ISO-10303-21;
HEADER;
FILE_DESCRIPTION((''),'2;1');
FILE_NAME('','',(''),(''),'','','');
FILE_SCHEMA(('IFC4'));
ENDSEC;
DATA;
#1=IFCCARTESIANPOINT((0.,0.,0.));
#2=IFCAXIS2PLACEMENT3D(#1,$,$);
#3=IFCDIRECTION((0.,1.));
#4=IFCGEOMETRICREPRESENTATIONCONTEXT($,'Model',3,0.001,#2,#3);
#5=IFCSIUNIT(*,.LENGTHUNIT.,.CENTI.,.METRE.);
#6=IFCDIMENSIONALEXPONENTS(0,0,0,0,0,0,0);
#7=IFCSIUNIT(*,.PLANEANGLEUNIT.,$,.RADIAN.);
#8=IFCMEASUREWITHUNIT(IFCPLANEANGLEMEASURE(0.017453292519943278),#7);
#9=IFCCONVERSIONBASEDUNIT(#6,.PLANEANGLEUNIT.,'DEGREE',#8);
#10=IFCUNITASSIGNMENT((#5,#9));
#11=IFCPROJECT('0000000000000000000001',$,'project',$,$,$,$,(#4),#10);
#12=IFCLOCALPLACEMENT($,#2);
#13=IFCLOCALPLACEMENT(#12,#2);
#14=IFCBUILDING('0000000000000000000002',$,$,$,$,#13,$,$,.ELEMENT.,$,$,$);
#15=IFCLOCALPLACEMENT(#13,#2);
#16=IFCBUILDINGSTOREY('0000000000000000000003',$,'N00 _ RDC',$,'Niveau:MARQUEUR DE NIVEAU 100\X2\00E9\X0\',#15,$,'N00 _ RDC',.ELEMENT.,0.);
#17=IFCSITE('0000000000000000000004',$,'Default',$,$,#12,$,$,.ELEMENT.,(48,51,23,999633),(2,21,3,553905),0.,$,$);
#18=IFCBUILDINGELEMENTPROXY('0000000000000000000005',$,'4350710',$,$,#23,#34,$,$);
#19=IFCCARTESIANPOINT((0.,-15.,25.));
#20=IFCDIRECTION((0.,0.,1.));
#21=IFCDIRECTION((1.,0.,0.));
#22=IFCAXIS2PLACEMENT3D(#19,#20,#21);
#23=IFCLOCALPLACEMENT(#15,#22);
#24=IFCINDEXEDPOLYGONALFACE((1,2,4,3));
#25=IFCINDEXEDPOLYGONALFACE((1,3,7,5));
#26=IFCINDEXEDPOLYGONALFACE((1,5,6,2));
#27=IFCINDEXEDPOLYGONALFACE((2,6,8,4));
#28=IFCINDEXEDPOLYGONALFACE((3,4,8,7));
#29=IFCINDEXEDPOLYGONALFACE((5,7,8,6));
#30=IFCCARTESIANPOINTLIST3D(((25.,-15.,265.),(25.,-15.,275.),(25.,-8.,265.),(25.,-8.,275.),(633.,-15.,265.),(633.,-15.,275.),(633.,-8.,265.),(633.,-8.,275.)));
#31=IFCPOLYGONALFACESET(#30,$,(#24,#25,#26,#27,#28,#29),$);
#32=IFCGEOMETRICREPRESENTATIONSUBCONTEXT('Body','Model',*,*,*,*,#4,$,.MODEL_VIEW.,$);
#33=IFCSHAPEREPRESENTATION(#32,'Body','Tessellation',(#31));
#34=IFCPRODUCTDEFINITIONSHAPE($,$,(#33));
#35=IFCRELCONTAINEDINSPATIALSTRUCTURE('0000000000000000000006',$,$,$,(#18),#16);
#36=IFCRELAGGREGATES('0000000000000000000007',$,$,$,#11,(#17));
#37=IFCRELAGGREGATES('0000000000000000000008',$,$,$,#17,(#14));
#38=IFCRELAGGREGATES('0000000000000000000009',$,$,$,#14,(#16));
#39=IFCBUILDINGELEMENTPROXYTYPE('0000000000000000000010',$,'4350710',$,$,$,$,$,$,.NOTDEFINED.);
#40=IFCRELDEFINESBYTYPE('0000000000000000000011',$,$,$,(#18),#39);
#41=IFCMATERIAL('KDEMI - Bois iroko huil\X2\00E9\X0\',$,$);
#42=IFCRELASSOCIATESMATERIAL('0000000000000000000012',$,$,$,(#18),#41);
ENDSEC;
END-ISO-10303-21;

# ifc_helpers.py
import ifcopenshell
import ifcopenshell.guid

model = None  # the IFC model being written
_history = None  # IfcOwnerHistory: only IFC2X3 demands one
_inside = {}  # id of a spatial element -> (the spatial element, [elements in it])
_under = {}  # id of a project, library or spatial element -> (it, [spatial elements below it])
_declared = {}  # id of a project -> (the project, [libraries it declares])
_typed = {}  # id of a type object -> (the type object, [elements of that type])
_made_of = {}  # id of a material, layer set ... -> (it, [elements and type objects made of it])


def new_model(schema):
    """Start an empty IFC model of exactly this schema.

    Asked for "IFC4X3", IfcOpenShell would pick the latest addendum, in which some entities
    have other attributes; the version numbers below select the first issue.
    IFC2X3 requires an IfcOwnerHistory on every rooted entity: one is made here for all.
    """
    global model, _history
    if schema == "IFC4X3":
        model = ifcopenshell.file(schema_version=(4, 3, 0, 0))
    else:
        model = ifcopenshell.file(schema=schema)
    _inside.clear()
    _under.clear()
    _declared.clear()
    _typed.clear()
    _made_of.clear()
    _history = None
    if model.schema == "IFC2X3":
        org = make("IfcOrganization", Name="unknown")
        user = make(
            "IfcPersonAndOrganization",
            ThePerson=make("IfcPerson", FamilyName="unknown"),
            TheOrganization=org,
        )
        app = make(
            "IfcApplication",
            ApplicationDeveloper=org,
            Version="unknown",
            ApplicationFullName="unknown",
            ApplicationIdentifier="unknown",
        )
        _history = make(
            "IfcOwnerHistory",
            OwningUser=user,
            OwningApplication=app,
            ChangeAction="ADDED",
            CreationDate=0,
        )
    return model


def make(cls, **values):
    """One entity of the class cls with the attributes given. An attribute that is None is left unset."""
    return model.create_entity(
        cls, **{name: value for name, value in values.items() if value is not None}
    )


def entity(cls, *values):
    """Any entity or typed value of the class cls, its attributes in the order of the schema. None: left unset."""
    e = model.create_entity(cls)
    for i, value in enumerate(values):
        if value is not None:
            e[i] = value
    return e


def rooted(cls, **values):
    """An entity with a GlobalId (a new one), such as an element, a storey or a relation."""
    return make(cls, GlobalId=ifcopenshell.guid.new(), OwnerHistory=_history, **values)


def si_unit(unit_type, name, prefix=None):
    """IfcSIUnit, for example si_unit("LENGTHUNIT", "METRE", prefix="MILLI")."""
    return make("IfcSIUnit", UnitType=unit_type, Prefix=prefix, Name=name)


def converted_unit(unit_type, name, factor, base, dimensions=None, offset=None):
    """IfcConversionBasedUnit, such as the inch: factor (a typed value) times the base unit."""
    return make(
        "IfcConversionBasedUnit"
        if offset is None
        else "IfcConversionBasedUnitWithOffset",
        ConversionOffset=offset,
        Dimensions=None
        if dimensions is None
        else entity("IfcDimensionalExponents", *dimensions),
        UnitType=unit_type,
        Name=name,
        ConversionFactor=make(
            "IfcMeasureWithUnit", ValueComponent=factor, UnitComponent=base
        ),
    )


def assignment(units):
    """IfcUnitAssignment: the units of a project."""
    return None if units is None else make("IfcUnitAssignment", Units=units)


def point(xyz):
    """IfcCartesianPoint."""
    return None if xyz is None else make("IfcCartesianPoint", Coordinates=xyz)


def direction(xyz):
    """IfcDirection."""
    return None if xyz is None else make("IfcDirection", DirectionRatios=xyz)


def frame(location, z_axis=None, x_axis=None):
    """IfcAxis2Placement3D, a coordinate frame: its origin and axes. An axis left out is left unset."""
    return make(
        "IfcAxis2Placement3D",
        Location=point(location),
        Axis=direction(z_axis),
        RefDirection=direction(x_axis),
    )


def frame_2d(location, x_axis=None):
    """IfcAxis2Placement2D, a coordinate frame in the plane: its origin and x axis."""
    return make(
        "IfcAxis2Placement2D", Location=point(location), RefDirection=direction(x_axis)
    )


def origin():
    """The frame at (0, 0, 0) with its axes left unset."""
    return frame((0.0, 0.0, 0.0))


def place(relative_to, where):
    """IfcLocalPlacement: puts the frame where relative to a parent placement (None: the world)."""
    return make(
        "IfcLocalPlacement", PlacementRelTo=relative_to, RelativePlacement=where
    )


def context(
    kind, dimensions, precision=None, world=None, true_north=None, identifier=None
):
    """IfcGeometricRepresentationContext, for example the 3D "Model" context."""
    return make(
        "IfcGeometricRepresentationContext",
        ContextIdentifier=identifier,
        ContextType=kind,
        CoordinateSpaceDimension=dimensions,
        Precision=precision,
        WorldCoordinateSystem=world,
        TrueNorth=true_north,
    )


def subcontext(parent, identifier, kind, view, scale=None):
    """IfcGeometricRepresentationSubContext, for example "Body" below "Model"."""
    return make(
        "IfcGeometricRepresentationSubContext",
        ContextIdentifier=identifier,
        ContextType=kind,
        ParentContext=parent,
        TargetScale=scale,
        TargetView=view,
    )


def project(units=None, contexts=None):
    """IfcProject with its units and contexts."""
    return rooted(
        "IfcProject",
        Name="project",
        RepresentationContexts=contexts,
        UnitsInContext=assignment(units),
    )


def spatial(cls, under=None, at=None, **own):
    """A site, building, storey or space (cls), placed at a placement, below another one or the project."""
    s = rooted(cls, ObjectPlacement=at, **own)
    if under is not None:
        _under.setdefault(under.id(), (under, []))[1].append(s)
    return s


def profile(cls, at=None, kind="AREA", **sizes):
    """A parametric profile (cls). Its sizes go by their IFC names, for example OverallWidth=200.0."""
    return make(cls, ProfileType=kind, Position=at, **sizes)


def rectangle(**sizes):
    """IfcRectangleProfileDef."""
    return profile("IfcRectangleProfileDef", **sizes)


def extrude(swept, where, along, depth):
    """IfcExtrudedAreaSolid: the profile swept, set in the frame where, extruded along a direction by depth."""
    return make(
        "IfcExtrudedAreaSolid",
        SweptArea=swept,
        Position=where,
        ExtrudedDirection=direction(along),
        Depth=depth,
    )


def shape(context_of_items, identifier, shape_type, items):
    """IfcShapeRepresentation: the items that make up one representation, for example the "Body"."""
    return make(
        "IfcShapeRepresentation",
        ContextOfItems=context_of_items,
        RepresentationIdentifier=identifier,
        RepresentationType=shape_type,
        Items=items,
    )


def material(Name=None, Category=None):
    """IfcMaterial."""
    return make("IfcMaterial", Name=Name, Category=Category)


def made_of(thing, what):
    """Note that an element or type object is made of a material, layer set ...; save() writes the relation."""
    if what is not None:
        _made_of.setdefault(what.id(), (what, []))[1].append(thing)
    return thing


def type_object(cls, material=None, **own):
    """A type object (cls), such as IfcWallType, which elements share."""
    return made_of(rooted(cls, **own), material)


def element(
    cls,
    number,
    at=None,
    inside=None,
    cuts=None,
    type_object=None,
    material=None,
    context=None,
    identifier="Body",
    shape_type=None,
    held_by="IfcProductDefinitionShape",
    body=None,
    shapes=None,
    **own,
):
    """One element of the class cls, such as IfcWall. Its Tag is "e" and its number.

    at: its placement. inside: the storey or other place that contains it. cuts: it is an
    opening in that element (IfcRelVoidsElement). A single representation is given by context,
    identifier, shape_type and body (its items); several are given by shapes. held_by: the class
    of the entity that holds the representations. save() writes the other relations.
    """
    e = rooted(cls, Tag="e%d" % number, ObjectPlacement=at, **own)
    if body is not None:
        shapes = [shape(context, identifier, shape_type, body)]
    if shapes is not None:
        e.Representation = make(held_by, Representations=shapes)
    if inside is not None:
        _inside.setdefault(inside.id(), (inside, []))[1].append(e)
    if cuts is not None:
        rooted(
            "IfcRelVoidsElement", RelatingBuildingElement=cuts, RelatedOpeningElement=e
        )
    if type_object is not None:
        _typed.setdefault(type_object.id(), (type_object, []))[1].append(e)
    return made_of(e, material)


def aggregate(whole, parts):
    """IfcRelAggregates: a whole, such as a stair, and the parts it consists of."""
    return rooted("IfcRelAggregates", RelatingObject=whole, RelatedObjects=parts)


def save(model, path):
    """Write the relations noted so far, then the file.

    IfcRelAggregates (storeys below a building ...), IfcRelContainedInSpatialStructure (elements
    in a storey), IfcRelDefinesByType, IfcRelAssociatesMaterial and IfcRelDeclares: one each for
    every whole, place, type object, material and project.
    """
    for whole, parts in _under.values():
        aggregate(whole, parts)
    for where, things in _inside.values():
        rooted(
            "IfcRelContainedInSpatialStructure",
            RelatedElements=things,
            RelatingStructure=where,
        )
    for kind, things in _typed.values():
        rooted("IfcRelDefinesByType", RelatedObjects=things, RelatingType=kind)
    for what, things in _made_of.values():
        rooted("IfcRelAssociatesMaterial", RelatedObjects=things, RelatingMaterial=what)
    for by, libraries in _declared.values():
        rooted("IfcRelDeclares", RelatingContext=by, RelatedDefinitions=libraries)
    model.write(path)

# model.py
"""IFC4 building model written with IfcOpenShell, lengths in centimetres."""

from ifc_helpers import new_model, entity, si_unit, converted_unit, direction, frame, frame_2d, origin, place, context, subcontext, project, spatial, rectangle, extrude, material, type_object, element, save


model = new_model("IFC4")

# Units and contexts
model_context = context("Model", 3, precision=0.001, world=origin(), true_north=direction((0.0, 1.0)))
body_context = subcontext(model_context, "Body", "Model", "MODEL_VIEW")
ifc_project = project(units=[si_unit("LENGTHUNIT", "METRE", prefix="CENTI"), converted_unit("PLANEANGLEUNIT", "DEGREE", entity("IfcPlaneAngleMeasure", 0.017453292519943278), si_unit("PLANEANGLEUNIT", "RADIAN"), dimensions=[0, 0, 0, 0, 0, 0, 0])], contexts=[model_context])

# Site, building, storey
site_placement = place(None, origin())
site = spatial("IfcSite", under=ifc_project, at=site_placement, Name="Default", CompositionType="ELEMENT", RefLatitude=(48, 51, 23, 999633), RefLongitude=(2, 21, 3, 553905), RefElevation=0.0)
building_placement = place(site_placement, origin())
building = spatial("IfcBuilding", under=site, at=building_placement, CompositionType="ELEMENT")
storey_placement = place(building_placement, origin())
storey = spatial("IfcBuildingStorey", under=building, at=storey_placement, Name="N00 _ RDC", ObjectType="Niveau:MARQUEUR DE NIVEAU 100é", LongName="N00 _ RDC", CompositionType="ELEMENT", Elevation=0.0)

# Shared definitions
ifc_material_1 = material(Name="KDEMI - Bois iroko huilé")

# Building element proxy
building_element_proxy_type_1 = type_object("IfcBuildingElementProxyType", Name="4350710", PredefinedType="NOTDEFINED")
proxy_1_placement = place(storey_placement, frame((0.0, -15.0, 25.0), z_axis=(0.0, 0.0, 1.0), x_axis=(1.0, 0.0, 0.0)))
element("IfcBuildingElementProxy", 1, at=proxy_1_placement, inside=storey, type_object=building_element_proxy_type_1, material=ifc_material_1, Name="4350710", context=body_context, shape_type="SweptSolid", body=[
    extrude(rectangle(XDim=608.0, YDim=7.0, at=frame_2d((0.0, 0.0), x_axis=(1.0, 0.0))), frame((329.0, -11.5, 265.0)), (0.0, 0.0, 1.0), 10.0),
])

save(model, "model.ifc")
